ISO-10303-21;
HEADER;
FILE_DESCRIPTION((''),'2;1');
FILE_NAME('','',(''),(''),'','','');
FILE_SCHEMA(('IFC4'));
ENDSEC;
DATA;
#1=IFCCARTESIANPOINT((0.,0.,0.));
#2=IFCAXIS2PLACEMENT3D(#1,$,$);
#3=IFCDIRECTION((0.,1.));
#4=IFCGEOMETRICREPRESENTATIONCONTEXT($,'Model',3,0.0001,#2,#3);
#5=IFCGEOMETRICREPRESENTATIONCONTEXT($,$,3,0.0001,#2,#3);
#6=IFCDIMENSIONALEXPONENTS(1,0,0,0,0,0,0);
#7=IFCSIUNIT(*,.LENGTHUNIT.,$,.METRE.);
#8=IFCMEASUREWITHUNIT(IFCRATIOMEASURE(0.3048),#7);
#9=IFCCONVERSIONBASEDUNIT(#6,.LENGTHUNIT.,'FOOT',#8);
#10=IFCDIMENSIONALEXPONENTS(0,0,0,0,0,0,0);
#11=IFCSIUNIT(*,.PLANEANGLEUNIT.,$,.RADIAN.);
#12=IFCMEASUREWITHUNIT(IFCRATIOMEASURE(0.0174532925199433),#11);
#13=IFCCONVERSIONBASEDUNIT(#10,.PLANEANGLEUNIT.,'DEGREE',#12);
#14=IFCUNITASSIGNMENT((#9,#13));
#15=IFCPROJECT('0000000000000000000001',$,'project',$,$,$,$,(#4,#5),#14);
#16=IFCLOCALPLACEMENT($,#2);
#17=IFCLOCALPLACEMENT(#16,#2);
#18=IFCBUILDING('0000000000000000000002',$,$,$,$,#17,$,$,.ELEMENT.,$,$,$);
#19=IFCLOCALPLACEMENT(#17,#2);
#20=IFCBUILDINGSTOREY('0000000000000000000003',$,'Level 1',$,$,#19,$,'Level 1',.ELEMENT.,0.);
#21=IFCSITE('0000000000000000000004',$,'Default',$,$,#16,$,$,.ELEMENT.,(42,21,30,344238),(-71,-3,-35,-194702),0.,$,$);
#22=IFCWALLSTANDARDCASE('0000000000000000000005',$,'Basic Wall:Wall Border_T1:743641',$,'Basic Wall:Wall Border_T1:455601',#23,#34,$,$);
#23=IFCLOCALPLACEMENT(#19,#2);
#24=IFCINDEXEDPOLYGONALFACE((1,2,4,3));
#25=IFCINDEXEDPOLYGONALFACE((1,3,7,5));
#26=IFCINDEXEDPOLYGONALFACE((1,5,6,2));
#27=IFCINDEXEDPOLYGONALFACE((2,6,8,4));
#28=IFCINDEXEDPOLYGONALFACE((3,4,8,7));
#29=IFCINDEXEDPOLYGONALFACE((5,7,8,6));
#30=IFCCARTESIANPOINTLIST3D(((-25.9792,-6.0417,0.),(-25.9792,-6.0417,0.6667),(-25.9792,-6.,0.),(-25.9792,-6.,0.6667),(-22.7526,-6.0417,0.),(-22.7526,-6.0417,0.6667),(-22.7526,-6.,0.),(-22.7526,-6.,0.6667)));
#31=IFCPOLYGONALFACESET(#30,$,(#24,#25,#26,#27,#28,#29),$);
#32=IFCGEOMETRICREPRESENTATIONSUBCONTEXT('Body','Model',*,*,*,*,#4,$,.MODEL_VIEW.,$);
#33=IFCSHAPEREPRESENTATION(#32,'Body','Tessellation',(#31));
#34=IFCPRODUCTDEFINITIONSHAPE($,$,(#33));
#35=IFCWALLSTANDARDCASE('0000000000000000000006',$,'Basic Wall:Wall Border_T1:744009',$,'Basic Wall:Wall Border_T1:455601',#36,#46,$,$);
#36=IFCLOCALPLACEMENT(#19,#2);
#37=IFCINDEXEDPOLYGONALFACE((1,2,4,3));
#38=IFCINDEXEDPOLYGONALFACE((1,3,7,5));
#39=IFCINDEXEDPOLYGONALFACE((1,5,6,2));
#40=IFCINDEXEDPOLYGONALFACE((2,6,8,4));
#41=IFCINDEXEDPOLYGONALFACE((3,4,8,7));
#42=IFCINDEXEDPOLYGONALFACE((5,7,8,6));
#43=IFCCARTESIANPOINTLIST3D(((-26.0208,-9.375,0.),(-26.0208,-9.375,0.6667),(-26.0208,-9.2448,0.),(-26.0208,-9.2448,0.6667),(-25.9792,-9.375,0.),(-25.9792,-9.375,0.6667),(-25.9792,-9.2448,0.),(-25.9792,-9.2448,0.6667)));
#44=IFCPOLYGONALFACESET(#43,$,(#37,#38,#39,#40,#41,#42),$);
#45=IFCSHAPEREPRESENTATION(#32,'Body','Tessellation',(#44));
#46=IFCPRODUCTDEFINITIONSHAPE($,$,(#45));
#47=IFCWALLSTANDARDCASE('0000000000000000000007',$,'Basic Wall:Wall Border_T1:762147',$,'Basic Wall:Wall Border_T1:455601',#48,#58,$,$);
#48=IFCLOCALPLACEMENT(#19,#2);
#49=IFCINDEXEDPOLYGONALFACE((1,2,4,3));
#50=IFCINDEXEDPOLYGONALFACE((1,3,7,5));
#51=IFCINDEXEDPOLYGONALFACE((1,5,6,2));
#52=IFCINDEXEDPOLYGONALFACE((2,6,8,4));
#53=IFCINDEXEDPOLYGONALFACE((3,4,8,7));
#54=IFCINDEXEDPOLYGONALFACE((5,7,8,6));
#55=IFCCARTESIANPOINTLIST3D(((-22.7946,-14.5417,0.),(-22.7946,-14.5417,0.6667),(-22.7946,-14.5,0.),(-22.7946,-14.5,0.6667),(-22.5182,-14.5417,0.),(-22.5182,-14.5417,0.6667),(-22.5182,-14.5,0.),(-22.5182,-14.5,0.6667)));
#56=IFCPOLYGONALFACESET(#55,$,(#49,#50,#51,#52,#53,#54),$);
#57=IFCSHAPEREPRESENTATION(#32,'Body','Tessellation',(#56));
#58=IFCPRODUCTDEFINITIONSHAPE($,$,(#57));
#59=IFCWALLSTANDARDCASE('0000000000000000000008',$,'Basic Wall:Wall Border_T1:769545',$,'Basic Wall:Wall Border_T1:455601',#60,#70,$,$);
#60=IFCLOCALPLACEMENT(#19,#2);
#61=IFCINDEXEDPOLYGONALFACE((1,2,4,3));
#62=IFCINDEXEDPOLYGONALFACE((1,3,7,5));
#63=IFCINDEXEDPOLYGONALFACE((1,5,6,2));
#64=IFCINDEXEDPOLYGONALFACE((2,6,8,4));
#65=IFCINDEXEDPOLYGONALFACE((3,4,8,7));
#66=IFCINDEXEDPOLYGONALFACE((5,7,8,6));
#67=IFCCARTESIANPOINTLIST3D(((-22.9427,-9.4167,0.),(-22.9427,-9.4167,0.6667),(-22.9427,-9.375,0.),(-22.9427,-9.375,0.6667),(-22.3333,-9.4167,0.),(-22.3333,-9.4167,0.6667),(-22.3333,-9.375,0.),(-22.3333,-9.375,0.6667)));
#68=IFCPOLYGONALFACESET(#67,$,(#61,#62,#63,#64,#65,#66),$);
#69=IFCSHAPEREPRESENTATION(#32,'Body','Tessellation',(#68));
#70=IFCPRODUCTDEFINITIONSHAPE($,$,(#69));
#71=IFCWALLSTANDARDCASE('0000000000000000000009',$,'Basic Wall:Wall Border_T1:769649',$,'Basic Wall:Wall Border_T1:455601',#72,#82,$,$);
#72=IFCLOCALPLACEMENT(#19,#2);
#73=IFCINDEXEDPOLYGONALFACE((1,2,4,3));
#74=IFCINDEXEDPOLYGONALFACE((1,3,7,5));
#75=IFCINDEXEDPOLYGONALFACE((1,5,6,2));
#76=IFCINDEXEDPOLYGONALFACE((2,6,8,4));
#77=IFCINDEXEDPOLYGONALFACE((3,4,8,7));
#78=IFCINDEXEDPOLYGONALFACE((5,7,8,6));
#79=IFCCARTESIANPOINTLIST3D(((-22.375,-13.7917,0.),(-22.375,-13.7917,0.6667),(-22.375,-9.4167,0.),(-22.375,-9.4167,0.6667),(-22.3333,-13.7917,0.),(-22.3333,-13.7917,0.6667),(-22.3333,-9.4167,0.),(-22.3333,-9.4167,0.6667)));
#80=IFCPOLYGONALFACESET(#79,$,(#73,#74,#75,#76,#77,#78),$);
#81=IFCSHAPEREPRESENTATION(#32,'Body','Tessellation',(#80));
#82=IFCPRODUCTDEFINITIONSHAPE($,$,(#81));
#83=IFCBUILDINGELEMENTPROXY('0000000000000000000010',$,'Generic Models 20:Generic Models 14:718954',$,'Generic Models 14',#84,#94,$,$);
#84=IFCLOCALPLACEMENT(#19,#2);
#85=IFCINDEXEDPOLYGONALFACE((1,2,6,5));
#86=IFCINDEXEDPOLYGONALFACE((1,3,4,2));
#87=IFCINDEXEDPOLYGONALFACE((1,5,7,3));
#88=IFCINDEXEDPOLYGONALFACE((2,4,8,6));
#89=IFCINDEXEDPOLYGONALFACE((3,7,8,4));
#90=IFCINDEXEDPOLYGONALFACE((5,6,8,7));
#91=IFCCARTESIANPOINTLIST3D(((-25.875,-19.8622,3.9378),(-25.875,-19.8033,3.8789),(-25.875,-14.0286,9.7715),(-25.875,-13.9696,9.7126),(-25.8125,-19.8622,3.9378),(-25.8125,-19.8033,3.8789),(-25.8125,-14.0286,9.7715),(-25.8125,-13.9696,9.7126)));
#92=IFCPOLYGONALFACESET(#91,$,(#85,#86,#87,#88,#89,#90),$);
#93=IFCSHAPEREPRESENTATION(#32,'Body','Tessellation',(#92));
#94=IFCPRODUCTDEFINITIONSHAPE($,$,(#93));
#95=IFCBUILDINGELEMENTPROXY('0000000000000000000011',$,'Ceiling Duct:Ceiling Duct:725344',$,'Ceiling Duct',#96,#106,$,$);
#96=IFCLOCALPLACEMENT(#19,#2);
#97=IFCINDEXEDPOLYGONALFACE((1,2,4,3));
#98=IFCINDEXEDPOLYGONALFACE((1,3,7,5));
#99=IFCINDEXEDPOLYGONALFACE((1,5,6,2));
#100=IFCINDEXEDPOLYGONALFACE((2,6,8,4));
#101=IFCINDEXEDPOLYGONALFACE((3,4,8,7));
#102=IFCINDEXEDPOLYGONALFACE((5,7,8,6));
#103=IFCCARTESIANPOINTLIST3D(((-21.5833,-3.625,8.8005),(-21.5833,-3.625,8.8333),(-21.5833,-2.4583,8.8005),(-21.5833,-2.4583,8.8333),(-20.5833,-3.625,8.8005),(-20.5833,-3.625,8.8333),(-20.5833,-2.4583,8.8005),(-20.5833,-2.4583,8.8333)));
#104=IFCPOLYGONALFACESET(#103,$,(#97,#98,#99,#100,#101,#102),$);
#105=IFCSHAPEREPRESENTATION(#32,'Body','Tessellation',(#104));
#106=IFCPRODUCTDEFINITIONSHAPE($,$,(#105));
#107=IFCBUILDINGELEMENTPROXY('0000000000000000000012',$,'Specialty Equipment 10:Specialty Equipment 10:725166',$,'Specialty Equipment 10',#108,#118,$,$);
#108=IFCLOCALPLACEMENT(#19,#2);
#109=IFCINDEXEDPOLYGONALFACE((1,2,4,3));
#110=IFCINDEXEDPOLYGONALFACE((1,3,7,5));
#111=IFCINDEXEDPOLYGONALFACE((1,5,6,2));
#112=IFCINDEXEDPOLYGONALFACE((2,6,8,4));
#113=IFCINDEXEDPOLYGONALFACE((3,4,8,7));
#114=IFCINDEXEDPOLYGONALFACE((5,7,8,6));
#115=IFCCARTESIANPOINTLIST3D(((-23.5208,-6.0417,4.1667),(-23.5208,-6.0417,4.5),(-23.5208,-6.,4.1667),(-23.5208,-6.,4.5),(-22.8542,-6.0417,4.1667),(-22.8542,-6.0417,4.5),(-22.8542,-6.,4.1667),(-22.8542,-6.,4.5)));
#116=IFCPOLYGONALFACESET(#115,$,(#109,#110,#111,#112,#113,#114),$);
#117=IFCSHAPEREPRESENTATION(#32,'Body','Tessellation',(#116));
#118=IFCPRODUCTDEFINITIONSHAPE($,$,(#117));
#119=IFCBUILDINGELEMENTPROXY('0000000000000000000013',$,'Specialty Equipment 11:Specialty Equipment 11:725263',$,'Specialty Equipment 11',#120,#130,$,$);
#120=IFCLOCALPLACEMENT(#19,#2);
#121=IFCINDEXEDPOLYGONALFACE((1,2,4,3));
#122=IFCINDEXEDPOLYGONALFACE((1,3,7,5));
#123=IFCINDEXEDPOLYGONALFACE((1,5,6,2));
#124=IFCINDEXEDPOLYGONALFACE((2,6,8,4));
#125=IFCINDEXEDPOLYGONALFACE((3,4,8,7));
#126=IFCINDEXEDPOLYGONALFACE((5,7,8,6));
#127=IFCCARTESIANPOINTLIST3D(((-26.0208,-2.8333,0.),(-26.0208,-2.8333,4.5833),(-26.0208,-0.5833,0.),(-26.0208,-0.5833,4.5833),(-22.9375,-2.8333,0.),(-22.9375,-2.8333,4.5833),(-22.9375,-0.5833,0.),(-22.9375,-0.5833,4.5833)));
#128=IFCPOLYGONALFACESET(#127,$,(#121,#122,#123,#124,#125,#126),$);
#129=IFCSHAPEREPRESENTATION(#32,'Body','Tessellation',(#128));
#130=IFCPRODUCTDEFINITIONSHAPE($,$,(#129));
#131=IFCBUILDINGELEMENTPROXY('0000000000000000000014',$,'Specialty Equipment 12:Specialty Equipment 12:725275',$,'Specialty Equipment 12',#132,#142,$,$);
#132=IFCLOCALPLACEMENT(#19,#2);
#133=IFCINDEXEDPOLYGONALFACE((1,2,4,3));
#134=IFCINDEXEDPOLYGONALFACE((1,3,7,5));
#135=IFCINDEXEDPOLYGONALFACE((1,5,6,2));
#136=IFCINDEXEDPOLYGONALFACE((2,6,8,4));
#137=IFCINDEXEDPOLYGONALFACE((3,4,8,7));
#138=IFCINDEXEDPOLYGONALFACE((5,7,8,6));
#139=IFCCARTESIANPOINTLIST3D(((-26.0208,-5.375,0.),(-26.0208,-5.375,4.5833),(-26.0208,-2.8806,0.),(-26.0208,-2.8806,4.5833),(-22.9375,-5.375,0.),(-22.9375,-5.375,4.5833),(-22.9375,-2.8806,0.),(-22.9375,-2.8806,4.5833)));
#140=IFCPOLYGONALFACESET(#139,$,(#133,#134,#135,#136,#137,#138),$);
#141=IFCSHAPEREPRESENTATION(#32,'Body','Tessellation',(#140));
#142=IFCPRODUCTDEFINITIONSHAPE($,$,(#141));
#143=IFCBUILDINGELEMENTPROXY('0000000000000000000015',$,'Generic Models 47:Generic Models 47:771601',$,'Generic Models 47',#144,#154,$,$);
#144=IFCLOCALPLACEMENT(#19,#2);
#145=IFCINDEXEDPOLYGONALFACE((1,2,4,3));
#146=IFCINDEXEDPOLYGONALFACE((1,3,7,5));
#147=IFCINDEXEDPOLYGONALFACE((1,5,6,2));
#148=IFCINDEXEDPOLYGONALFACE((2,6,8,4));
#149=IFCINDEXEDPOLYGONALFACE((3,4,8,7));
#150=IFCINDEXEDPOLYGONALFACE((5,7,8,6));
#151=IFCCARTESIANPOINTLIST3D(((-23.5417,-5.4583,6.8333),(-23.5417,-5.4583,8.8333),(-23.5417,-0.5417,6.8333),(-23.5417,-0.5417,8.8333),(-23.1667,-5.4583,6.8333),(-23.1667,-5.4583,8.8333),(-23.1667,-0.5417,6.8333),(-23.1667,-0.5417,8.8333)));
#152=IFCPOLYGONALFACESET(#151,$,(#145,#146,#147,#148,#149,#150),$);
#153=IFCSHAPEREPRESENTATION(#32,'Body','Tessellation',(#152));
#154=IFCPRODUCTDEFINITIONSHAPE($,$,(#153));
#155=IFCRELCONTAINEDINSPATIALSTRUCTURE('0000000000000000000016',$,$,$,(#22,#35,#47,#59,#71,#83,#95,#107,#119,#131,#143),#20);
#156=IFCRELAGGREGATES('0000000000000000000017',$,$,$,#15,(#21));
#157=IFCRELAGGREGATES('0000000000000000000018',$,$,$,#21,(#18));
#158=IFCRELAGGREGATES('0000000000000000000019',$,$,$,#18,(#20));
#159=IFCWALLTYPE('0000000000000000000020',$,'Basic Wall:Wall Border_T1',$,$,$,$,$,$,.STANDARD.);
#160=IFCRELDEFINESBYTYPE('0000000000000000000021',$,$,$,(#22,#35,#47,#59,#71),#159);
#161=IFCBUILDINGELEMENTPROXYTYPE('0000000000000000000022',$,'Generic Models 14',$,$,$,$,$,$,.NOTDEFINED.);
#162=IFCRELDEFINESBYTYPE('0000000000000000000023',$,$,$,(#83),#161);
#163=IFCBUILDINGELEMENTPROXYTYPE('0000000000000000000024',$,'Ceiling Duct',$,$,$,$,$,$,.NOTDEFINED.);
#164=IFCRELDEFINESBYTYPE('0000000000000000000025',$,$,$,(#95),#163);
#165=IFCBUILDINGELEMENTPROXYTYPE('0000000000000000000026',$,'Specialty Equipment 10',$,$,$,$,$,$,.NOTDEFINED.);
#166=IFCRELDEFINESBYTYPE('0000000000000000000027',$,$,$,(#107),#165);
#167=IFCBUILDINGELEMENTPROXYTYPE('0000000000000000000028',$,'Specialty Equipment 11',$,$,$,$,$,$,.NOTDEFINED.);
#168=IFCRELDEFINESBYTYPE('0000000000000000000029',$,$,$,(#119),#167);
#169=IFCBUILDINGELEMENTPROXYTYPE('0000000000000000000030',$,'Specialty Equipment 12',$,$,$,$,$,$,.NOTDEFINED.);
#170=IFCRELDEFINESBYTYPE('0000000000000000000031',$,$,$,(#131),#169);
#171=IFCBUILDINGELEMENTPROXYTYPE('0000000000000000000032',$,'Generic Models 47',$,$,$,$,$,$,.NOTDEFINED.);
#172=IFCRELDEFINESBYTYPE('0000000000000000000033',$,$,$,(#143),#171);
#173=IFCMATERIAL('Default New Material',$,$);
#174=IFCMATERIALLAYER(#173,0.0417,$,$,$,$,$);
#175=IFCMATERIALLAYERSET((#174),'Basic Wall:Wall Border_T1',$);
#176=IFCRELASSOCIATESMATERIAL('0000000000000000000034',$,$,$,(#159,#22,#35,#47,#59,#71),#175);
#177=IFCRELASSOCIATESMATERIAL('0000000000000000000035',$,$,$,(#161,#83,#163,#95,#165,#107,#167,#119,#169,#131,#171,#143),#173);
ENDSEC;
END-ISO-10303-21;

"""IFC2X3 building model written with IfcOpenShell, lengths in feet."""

from ifc_helpers import new_model, entity, si_unit, converted_unit, direction, frame, frame_2d, origin, origin_2d_with_axis, place, context, subcontext, project, spatial, rectangle, extrude, source, transform, mapped, material, layer, layer_set, layer_usage, type_object, type_shapes, element, save


model = new_model("IFC2X3")

# Units and contexts
model_context = context("Model", 3, precision=0.0001, world=origin(), true_north=direction((0.0, 1.0)))
context_of_model = context(None, 3, precision=0.0001, world=origin(), true_north=direction((0.0, 1.0)))
body_context = subcontext(model_context, "Body", "Model", "MODEL_VIEW")
ifc_project = project(units=[converted_unit("LENGTHUNIT", "FOOT", entity("IfcRatioMeasure", 0.3048), si_unit("LENGTHUNIT", "METRE"), dimensions=[1, 0, 0, 0, 0, 0, 0]), converted_unit("PLANEANGLEUNIT", "DEGREE", entity("IfcRatioMeasure", 0.0174532925199433), si_unit("PLANEANGLEUNIT", "RADIAN"), dimensions=[0, 0, 0, 0, 0, 0, 0])], contexts=[model_context, context_of_model])

# Site, building, storey
site_placement = place(None, origin())
site = spatial("IfcSite", under=ifc_project, at=site_placement, Name="Default", CompositionType="ELEMENT", RefLatitude=(42, 21, 30, 344238), RefLongitude=(-71, -3, -35, -194702), RefElevation=0.0)
building_placement = place(site_placement, origin())
building = spatial("IfcBuilding", under=site, at=building_placement, CompositionType="ELEMENT")
storey_placement = place(building_placement, origin())
storey = spatial("IfcBuildingStorey", under=building, at=storey_placement, Name="Level 1", LongName="Level 1", CompositionType="ELEMENT", Elevation=0.0)

# Shared definitions
ifc_material = material(Name="Default New Material")

# Walls
ifc_layer_1 = layer(ifc_material, 0.0417)
ifc_layer_set_1 = layer_set([ifc_layer_1], Name="Basic Wall:Wall Border_T1")
wall_type_1 = type_object("IfcWallType", Name="Basic Wall:Wall Border_T1", PredefinedType="STANDARD", material=ifc_layer_set_1)
ifc_layer_usage_1 = layer_usage(ifc_layer_set_1, "AXIS2", "POSITIVE", -0.0208)
wall_1_placement = place(storey_placement, frame((-25.9792, -6.0208, 0.0)))
element("IfcWallStandardCase", 1, at=wall_1_placement, inside=storey, type_object=wall_type_1, material=ifc_layer_usage_1, Name="Basic Wall:Wall Border_T1:743641", ObjectType="Basic Wall:Wall Border_T1:455601", context=body_context, shape_type="SweptSolid", body=[
    extrude(rectangle(XDim=3.2265, YDim=0.0417, at=frame_2d((1.6133, 0.0), x_axis=(-1.0, 0.0))), origin(), (0.0, 0.0, 1.0), 0.6667),
])
ifc_layer_usage_2 = layer_usage(ifc_layer_set_1, "AXIS2", "POSITIVE", -0.0208)
wall_2_placement = place(storey_placement, frame((-26.0, -9.375, 0.0), z_axis=(0.0, 0.0, 1.0), x_axis=(0.0, 1.0, 0.0)))
element("IfcWallStandardCase", 2, at=wall_2_placement, inside=storey, type_object=wall_type_1, material=ifc_layer_usage_2, Name="Basic Wall:Wall Border_T1:744009", ObjectType="Basic Wall:Wall Border_T1:455601", context=body_context, shape_type="SweptSolid", body=[
    extrude(rectangle(XDim=0.1302, YDim=0.0417, at=frame_2d((0.0651, 0.0), x_axis=(-1.0, 0.0))), origin(), (0.0, 0.0, 1.0), 0.6667),
])
ifc_layer_usage_3 = layer_usage(ifc_layer_set_1, "AXIS2", "POSITIVE", -0.0208)
wall_3_placement = place(storey_placement, frame((-22.7946, -14.5208, 0.0)))
element("IfcWallStandardCase", 3, at=wall_3_placement, inside=storey, type_object=wall_type_1, material=ifc_layer_usage_3, Name="Basic Wall:Wall Border_T1:762147", ObjectType="Basic Wall:Wall Border_T1:455601", context=body_context, shape_type="SweptSolid", body=[
    extrude(rectangle(XDim=0.2764, YDim=0.0417, at=frame_2d((0.1382, 0.0), x_axis=(-1.0, 0.0))), origin(), (0.0, 0.0, 1.0), 0.6667),
])

# Walls
ifc_layer_usage_4 = layer_usage(ifc_layer_set_1, "AXIS2", "NEGATIVE", 0.0208)
wall_4_placement = place(storey_placement, frame((-22.9427, -9.3958, 0.0)))
element("IfcWallStandardCase", 4, at=wall_4_placement, inside=storey, type_object=wall_type_1, material=ifc_layer_usage_4, Name="Basic Wall:Wall Border_T1:769545", ObjectType="Basic Wall:Wall Border_T1:455601", context=body_context, shape_type="SweptSolid", body=[
    extrude(rectangle(XDim=0.6094, YDim=0.0417, at=frame_2d((0.3047, 0.0), x_axis=(-1.0, 0.0))), origin(), (0.0, 0.0, 1.0), 0.6667),
])
ifc_layer_usage_5 = layer_usage(ifc_layer_set_1, "AXIS2", "NEGATIVE", 0.0208)
wall_5_placement = place(storey_placement, frame((-22.3542, -9.4167, 0.0), z_axis=(0.0, 0.0, 1.0), x_axis=(0.0, -1.0, 0.0)))
element("IfcWallStandardCase", 5, at=wall_5_placement, inside=storey, type_object=wall_type_1, material=ifc_layer_usage_5, Name="Basic Wall:Wall Border_T1:769649", ObjectType="Basic Wall:Wall Border_T1:455601", context=body_context, shape_type="SweptSolid", body=[
    extrude(rectangle(XDim=4.375, YDim=0.0417, at=frame_2d((2.1875, 0.0), x_axis=(-1.0, 0.0))), origin(), (0.0, 0.0, 1.0), 0.6667),
])

# Building element proxies
building_element_proxy_type_1 = type_object("IfcBuildingElementProxyType", Name="Generic Models 14", PredefinedType="NOTDEFINED", material=ifc_material)
shared_shape_1 = source(origin(), body_context, "Body", "SweptSolid", [
    extrude(rectangle(XDim=0.0833, YDim=0.0625, at=frame_2d((0.0, 0.0), x_axis=(1.0, 0.0))), frame((0.0312, 0.0295, 0.0295), z_axis=(0.0, 0.707107, 0.707107), x_axis=(0.0, 0.707107, -0.707107)), (0.0, 0.0, 1.0), 8.25),
])
type_shapes(building_element_proxy_type_1, [shared_shape_1])
proxy_1_placement = place(storey_placement, frame((-25.875, -19.8622, 3.8789)))
element("IfcBuildingElementProxy", 6, at=proxy_1_placement, inside=storey, type_object=building_element_proxy_type_1, material=ifc_material, Name="Generic Models 20:Generic Models 14:718954", ObjectType="Generic Models 14", context=body_context, shape_type="MappedRepresentation", body=[
    mapped(shared_shape_1, transform((0.0, 0.0, 0.0), scale=1.0)),
])
building_element_proxy_type_2 = type_object("IfcBuildingElementProxyType", Name="Ceiling Duct", PredefinedType="NOTDEFINED", material=ifc_material)
shared_shape_2 = source(origin(), body_context, "Body", "SweptSolid", [
    extrude(rectangle(XDim=1.0, YDim=1.1667, at=origin_2d_with_axis()), frame((0.5833, -0.5, -0.0328), z_axis=(0.0, 0.0, 1.0), x_axis=(0.0, 1.0, 0.0)), (0.0, 0.0, 1.0), 0.0328),
])
type_shapes(building_element_proxy_type_2, [shared_shape_2])
proxy_2_placement = place(storey_placement, frame((-20.5833, -2.4583, 8.8333), z_axis=(0.0, 0.0, 1.0), x_axis=(0.0, -1.0, 0.0)))
element("IfcBuildingElementProxy", 7, at=proxy_2_placement, inside=storey, type_object=building_element_proxy_type_2, material=ifc_material, Name="Ceiling Duct:Ceiling Duct:725344", ObjectType="Ceiling Duct", context=body_context, shape_type="MappedRepresentation", body=[
    mapped(shared_shape_2, transform((0.0, 0.0, 0.0), scale=1.0)),
])
building_element_proxy_type_3 = type_object("IfcBuildingElementProxyType", Name="Specialty Equipment 10", PredefinedType="NOTDEFINED", material=ifc_material)
shared_shape_3 = source(origin(), body_context, "Body", "SweptSolid", [
    extrude(rectangle(XDim=0.0417, YDim=0.6667, at=frame_2d((0.0, 0.0), x_axis=(1.0, 0.0))), frame((0.3333, 0.0208, 0.0), z_axis=(0.0, 0.0, 1.0), x_axis=(0.0, 1.0, 0.0)), (0.0, 0.0, 1.0), 0.3333),
])
type_shapes(building_element_proxy_type_3, [shared_shape_3])
proxy_3_placement = place(storey_placement, frame((-23.5208, -6.0417, 4.1667)))
element("IfcBuildingElementProxy", 8, at=proxy_3_placement, inside=storey, type_object=building_element_proxy_type_3, material=ifc_material, Name="Specialty Equipment 10:Specialty Equipment 10:725166", ObjectType="Specialty Equipment 10", context=body_context, shape_type="MappedRepresentation", body=[
    mapped(shared_shape_3, transform((0.0, 0.0, 0.0), scale=1.0)),
])
building_element_proxy_type_4 = type_object("IfcBuildingElementProxyType", Name="Specialty Equipment 11", PredefinedType="NOTDEFINED", material=ifc_material)
shared_shape_4 = source(origin(), body_context, "Body", "SweptSolid", [
    extrude(rectangle(XDim=2.25, YDim=3.0833, at=frame_2d((0.0, 0.0), x_axis=(1.0, 0.0))), frame((1.5417, 1.125, 0.0), z_axis=(0.0, 0.0, 1.0), x_axis=(0.0, -1.0, 0.0)), (0.0, 0.0, 1.0), 4.5833),
])
type_shapes(building_element_proxy_type_4, [shared_shape_4])
proxy_4_placement = place(storey_placement, frame((-26.0208, -2.8333, 0.0)))
element("IfcBuildingElementProxy", 9, at=proxy_4_placement, inside=storey, type_object=building_element_proxy_type_4, material=ifc_material, Name="Specialty Equipment 11:Specialty Equipment 11:725263", ObjectType="Specialty Equipment 11", context=body_context, shape_type="MappedRepresentation", body=[
    mapped(shared_shape_4, transform((0.0, 0.0, 0.0), scale=1.0)),
])
building_element_proxy_type_5 = type_object("IfcBuildingElementProxyType", Name="Specialty Equipment 12", PredefinedType="NOTDEFINED", material=ifc_material)
shared_shape_5 = source(origin(), body_context, "Body", "SweptSolid", [
    extrude(rectangle(XDim=2.4944, YDim=3.0833, at=origin_2d_with_axis()), frame((1.5417, 1.2472, 0.0), z_axis=(0.0, 0.0, 1.0), x_axis=(0.0, -1.0, 0.0)), (0.0, 0.0, 1.0), 4.5833),
])
type_shapes(building_element_proxy_type_5, [shared_shape_5])
proxy_5_placement = place(storey_placement, frame((-26.0208, -5.375, 0.0)))
element("IfcBuildingElementProxy", 10, at=proxy_5_placement, inside=storey, type_object=building_element_proxy_type_5, material=ifc_material, Name="Specialty Equipment 12:Specialty Equipment 12:725275", ObjectType="Specialty Equipment 12", context=body_context, shape_type="MappedRepresentation", body=[
    mapped(shared_shape_5, transform((0.0, 0.0, 0.0), scale=1.0)),
])
building_element_proxy_type_6 = type_object("IfcBuildingElementProxyType", Name="Generic Models 47", PredefinedType="NOTDEFINED", material=ifc_material)
shared_shape_6 = source(origin(), body_context, "Body", "SweptSolid", [
    extrude(rectangle(XDim=4.9167, YDim=0.375, at=frame_2d((0.0, 0.0), x_axis=(1.0, 0.0))), frame((0.1875, 2.4583, 0.0), z_axis=(0.0, 0.0, 1.0), x_axis=(0.0, -1.0, 0.0)), (0.0, 0.0, 1.0), 2.0),
])
type_shapes(building_element_proxy_type_6, [shared_shape_6])
proxy_6_placement = place(storey_placement, frame((-23.5417, -5.4583, 6.8333)))
element("IfcBuildingElementProxy", 11, at=proxy_6_placement, inside=storey, type_object=building_element_proxy_type_6, material=ifc_material, Name="Generic Models 47:Generic Models 47:771601", ObjectType="Generic Models 47", context=body_context, shape_type="MappedRepresentation", body=[
    mapped(shared_shape_6, transform((0.0, 0.0, 0.0), scale=1.0)),
])

save(model, "model.ifc")
